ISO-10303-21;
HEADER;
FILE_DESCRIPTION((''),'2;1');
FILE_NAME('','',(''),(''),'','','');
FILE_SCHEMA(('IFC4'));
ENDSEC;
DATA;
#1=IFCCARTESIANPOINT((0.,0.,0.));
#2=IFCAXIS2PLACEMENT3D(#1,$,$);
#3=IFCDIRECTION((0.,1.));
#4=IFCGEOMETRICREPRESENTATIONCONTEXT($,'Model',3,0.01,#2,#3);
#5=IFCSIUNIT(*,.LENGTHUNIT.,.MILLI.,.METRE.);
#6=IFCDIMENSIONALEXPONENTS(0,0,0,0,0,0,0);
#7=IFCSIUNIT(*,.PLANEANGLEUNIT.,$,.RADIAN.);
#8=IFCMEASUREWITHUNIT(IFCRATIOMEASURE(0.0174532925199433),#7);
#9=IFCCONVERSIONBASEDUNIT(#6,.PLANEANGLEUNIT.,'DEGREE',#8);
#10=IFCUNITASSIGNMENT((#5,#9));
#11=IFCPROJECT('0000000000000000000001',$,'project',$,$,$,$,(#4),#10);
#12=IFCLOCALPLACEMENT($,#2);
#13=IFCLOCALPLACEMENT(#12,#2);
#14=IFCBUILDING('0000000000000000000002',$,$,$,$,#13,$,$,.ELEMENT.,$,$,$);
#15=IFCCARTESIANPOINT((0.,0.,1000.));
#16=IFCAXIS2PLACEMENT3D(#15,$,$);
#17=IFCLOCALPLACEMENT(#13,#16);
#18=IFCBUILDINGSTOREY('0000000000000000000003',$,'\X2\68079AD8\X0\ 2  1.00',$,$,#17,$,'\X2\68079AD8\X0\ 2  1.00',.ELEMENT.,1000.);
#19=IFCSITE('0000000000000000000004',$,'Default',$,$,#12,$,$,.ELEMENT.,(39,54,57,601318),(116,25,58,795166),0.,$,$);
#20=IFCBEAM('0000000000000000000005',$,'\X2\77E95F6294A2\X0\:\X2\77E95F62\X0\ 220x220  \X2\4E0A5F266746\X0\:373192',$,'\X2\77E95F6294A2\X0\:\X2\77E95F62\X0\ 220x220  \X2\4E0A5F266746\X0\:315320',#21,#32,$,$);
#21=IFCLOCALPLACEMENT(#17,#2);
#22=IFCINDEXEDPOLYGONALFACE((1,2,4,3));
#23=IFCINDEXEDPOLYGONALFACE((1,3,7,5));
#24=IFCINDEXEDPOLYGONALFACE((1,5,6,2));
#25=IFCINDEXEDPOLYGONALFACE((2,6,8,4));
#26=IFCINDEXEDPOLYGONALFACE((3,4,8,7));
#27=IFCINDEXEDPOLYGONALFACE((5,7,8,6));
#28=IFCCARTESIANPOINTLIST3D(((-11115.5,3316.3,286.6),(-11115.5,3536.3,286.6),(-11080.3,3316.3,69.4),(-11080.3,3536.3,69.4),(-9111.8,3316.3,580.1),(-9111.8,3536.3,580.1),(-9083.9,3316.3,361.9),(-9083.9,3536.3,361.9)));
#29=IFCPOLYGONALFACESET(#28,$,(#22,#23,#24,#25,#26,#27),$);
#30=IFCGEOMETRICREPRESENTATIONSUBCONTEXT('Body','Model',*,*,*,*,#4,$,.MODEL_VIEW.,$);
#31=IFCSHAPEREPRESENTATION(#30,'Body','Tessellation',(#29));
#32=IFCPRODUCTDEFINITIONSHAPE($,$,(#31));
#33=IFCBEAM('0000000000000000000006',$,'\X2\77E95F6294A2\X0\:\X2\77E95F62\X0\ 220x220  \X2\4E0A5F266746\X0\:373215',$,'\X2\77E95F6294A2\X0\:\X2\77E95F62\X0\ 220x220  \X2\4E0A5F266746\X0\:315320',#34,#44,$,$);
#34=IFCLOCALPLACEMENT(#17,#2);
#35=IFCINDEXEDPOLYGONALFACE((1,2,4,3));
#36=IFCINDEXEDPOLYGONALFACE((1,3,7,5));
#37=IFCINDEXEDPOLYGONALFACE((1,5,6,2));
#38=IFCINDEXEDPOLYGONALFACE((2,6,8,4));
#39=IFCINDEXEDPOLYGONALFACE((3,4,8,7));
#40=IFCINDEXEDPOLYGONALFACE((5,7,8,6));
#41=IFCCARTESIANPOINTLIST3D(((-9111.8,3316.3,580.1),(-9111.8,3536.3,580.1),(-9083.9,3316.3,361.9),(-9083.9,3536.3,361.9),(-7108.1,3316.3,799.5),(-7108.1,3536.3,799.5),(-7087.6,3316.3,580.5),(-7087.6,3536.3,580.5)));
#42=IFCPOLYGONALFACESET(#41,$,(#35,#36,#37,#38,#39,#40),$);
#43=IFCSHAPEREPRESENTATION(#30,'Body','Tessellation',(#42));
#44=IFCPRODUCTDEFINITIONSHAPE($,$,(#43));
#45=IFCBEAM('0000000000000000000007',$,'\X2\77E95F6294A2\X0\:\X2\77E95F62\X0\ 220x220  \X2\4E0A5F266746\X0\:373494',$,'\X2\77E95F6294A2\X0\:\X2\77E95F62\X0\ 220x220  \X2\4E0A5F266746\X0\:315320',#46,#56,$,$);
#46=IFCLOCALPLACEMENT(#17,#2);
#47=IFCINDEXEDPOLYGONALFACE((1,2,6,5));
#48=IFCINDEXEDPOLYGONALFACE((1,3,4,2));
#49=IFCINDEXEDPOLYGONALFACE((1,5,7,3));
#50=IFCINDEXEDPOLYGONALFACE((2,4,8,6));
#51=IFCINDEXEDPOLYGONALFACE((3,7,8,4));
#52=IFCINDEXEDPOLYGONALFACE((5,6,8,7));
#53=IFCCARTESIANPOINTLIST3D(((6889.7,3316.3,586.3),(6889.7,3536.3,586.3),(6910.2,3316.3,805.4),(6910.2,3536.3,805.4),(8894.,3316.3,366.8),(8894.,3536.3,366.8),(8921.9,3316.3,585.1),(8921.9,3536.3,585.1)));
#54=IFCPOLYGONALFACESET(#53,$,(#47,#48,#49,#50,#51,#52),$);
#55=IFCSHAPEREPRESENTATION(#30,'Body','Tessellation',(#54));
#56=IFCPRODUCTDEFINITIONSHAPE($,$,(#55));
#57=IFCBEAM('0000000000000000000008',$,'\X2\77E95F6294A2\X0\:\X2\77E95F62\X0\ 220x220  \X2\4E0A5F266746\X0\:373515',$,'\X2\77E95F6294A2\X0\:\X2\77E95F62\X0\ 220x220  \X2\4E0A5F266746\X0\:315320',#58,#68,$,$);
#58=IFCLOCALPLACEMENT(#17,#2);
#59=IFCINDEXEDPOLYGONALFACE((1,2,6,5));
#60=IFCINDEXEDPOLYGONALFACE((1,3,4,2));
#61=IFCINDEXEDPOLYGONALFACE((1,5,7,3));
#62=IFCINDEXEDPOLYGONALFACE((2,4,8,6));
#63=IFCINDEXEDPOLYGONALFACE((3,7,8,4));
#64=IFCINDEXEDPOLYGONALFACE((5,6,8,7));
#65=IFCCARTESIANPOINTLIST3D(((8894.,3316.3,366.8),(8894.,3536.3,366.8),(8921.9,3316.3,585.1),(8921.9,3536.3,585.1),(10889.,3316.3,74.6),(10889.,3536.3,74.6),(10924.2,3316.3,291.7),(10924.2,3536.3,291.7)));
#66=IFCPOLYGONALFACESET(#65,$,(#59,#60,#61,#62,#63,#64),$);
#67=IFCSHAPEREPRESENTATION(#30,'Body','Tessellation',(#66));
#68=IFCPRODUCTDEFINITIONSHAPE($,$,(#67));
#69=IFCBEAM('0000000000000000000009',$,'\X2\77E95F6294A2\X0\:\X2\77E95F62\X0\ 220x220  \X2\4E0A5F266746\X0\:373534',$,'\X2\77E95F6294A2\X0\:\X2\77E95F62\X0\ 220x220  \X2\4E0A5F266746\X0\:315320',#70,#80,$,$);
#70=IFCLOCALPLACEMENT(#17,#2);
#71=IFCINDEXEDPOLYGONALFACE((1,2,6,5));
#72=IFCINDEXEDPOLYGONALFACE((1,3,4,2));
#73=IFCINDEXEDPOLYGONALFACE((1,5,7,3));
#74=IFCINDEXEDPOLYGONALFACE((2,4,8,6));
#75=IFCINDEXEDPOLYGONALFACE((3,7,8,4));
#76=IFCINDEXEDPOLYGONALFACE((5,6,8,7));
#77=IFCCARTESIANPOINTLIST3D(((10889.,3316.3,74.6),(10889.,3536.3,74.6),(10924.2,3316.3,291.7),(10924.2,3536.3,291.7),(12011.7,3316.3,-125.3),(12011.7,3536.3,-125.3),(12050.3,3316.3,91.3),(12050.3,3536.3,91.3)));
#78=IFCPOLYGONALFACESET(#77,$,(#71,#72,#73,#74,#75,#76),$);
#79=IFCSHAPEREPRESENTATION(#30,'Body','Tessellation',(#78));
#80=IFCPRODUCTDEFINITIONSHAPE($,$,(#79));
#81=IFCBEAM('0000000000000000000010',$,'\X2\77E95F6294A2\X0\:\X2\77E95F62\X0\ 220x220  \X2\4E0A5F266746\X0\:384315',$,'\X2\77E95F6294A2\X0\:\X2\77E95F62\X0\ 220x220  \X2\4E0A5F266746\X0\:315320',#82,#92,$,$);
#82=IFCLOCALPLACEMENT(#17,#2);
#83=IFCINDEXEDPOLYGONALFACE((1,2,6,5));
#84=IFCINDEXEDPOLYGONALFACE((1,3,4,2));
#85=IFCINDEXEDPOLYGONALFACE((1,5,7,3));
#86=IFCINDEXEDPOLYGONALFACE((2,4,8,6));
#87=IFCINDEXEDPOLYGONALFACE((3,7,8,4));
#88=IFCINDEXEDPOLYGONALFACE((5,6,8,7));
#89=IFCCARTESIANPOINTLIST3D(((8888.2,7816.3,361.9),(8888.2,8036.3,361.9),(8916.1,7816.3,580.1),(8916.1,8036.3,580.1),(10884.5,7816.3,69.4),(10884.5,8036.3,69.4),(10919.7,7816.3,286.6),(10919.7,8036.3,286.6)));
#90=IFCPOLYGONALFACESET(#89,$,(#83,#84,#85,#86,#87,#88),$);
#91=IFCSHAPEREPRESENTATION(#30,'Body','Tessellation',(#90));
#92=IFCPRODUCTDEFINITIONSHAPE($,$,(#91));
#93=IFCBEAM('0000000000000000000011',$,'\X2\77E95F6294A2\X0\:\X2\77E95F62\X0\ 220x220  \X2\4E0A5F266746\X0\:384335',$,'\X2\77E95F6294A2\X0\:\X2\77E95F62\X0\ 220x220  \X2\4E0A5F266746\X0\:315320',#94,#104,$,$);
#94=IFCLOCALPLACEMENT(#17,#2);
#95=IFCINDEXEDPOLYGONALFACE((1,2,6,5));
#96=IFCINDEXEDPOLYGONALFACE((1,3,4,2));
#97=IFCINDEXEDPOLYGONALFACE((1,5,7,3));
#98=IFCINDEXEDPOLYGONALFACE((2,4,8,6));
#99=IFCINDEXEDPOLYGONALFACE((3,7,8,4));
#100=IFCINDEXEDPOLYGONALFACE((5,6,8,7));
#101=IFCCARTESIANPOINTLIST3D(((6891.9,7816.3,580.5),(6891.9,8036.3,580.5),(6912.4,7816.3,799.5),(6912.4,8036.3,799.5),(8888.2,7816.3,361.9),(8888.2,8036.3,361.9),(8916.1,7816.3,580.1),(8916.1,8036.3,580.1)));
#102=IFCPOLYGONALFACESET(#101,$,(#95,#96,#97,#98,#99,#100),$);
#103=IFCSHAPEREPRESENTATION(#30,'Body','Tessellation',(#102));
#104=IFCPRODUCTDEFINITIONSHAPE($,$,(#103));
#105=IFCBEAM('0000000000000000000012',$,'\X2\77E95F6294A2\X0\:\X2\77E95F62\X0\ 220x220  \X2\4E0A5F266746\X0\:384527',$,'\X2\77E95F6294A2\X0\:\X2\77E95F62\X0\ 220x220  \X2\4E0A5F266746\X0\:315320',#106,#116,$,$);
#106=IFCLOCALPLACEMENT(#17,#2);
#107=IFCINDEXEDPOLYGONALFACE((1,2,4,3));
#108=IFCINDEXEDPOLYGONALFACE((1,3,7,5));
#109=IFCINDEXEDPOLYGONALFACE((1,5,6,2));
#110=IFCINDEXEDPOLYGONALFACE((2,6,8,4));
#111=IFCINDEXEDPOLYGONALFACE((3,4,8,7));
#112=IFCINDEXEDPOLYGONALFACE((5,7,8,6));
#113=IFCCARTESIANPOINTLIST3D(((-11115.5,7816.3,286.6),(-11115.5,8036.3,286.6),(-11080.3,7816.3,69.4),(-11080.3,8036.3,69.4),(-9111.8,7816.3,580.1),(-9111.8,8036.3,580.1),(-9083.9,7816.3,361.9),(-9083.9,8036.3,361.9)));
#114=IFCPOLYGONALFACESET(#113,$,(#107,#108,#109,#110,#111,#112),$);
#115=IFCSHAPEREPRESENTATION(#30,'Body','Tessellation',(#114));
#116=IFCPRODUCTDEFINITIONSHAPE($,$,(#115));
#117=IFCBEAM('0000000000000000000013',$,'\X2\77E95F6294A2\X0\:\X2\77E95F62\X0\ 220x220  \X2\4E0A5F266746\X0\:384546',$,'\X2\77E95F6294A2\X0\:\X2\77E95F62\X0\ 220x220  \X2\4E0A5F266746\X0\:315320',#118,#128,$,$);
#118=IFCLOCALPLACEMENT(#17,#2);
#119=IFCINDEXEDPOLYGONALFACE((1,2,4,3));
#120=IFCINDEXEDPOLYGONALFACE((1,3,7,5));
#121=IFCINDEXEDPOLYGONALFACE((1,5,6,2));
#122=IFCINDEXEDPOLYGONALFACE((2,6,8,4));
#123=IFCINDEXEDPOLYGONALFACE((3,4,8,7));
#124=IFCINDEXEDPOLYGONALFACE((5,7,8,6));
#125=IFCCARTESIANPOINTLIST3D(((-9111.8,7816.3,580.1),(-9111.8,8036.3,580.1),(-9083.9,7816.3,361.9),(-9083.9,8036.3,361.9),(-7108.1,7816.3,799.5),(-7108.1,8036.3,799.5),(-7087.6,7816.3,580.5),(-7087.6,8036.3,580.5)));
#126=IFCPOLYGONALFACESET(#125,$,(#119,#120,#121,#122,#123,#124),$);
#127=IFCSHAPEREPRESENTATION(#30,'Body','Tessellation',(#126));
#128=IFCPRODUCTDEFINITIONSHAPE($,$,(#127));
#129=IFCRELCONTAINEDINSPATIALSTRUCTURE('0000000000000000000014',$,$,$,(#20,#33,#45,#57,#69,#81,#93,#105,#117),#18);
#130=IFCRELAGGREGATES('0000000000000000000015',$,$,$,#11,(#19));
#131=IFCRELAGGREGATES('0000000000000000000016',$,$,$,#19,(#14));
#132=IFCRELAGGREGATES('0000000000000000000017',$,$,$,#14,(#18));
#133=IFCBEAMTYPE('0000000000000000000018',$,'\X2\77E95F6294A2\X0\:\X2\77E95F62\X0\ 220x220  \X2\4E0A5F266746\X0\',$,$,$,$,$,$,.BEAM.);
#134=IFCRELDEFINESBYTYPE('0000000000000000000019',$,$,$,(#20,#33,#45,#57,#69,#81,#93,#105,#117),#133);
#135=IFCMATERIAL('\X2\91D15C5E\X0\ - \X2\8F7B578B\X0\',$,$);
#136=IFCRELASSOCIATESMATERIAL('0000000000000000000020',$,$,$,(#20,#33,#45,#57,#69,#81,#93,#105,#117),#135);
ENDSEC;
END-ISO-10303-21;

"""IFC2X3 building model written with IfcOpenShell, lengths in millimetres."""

from ifc_helpers import new_model, entity, si_unit, converted_unit, direction, frame, frame_2d, origin, origin_2d_with_axis, place, context, subcontext, project, spatial, rectangle, extrude, clip, halfspace, material, type_object, element, save


model = new_model("IFC2X3")

# Units and contexts
model_context = context("Model", 3, precision=0.01, world=origin(), true_north=direction((0.0, 1.0)))
body_context = subcontext(model_context, "Body", "Model", "MODEL_VIEW")
ifc_project = project(units=[si_unit("LENGTHUNIT", "METRE", prefix="MILLI"), converted_unit("PLANEANGLEUNIT", "DEGREE", entity("IfcRatioMeasure", 0.0174532925199433), si_unit("PLANEANGLEUNIT", "RADIAN"), dimensions=[0, 0, 0, 0, 0, 0, 0])], contexts=[model_context])

# Site, building, storey
site_placement = place(None, origin())
site = spatial("IfcSite", under=ifc_project, at=site_placement, Name="Default", CompositionType="ELEMENT", RefLatitude=(39, 54, 57, 601318), RefLongitude=(116, 25, 58, 795166), RefElevation=0.0)
building_placement = place(site_placement, origin())
building = spatial("IfcBuilding", under=site, at=building_placement, CompositionType="ELEMENT")
storey_placement = place(building_placement, frame((0.0, 0.0, 1000.0)))
storey = spatial("IfcBuildingStorey", under=building, at=storey_placement, Name="标高 2  1.00", LongName="标高 2  1.00", CompositionType="ELEMENT", Elevation=1000.0)

# Beams
ifc_material = material(Name="金属 - 轻型")
beam_type = type_object("IfcBeamType", Name="矩形钢:矩形 220x220  上弦杆", PredefinedType="BEAM")
beam_1_placement = place(storey_placement, frame((-11097.9, 3426.3, 178.0), z_axis=(-0.144953, 0.0, 0.989439), x_axis=(0.989439, 0.0, 0.144953)))
element("IfcBeam", 1, at=beam_1_placement, inside=storey, type_object=beam_type, material=ifc_material, Name="矩形钢:矩形 220x220  上弦杆:373192", ObjectType="矩形钢:矩形 220x220  上弦杆:315320", context=body_context, shape_type="Clipping", body=[
    clip(clip(extrude(rectangle(XDim=220.0, YDim=220.0, at=frame_2d((0.0, 0.0), x_axis=(1.0, 0.0))), frame((-1.7, 0.0, 0.0), z_axis=(1.0, 0.0, 0.0), x_axis=(0.0, 0.0, -1.0)), (0.0, 0.0, 1.0), 2025.0), halfspace(frame((2023.4, 0.0, 110.0), z_axis=(0.999834, 0.0, -0.018199), x_axis=(-0.018199, 0.0, -0.999834)), False)), halfspace(frame((-1.7, 0.0, 110.0), z_axis=(-0.999882, 0.0, -0.015344), x_axis=(0.015344, 0.0, -0.999882)), False)),
])
beam_2_placement = place(storey_placement, frame((-9097.9, 3426.3, 471.0), z_axis=(-0.108849, 0.0, 0.994058), x_axis=(0.994058, 0.0, 0.108849)))
element("IfcBeam", 2, at=beam_2_placement, inside=storey, type_object=beam_type, material=ifc_material, Name="矩形钢:矩形 220x220  上弦杆:373215", ObjectType="矩形钢:矩形 220x220  上弦杆:315320", context=body_context, shape_type="Clipping", body=[
    clip(clip(extrude(rectangle(XDim=220.0, YDim=220.0, at=origin_2d_with_axis()), frame((-2.0, 0.0, 0.0), z_axis=(1.0, 0.0, 0.0), x_axis=(0.0, 0.0, -1.0)), (0.0, 0.0, 1.0), 2015.7), halfspace(frame((2013.7, 0.0, 110.0), z_axis=(0.999878, 0.0, -0.015611), x_axis=(-0.015611, 0.0, -0.999878)), False)), halfspace(frame((-2.0, 0.0, 110.0), z_axis=(-0.999834, 0.0, -0.018199), x_axis=(0.018199, 0.0, -0.999834)), False)),
])
beam_3_placement = place(storey_placement, frame((6899.9, 3426.3, 695.8), z_axis=(0.108849, 0.0, 0.994058), x_axis=(0.994058, 0.0, -0.108849)))
element("IfcBeam", 3, at=beam_3_placement, inside=storey, type_object=beam_type, material=ifc_material, Name="矩形钢:矩形 220x220  上弦杆:373494", ObjectType="矩形钢:矩形 220x220  上弦杆:315320", context=body_context, shape_type="Clipping", body=[
    clip(clip(extrude(rectangle(XDim=220.0, YDim=220.0, at=frame_2d((0.0, 0.0), x_axis=(1.0, 0.0))), frame((-1.7, 0.0, 0.0), z_axis=(1.0, 0.0, 0.0), x_axis=(0.0, 0.0, -1.0)), (0.0, 0.0, 1.0), 2023.7), halfspace(frame((2022.0, 0.0, 110.0), z_axis=(0.999834, 0.0, -0.018199), x_axis=(0.018199, 0.0, 0.999834)), False)), halfspace(frame((-1.7, 0.0, 110.0), z_axis=(-0.999878, 0.0, -0.015611), x_axis=(-0.015611, 0.0, 0.999878)), False)),
])
beam_4_placement = place(storey_placement, frame((8907.9, 3426.3, 476.0), z_axis=(0.144953, 0.0, 0.989439), x_axis=(0.989439, 0.0, -0.144953)))
element("IfcBeam", 4, at=beam_4_placement, inside=storey, type_object=beam_type, material=ifc_material, Name="矩形钢:矩形 220x220  上弦杆:373515", ObjectType="矩形钢:矩形 220x220  上弦杆:315320", context=body_context, shape_type="Clipping", body=[
    clip(clip(extrude(rectangle(XDim=220.0, YDim=220.0, at=frame_2d((0.0, 0.0), x_axis=(1.0, 0.0))), frame((-2.0, 0.0, 0.0), z_axis=(1.0, 0.0, 0.0), x_axis=(0.0, 0.0, -1.0)), (0.0, 0.0, 1.0), 2023.7), halfspace(frame((2021.7, 0.0, 110.0), z_axis=(0.999882, 0.0, -0.015344), x_axis=(0.015344, 0.0, 0.999882)), False)), halfspace(frame((-2.0, 0.0, 110.0), z_axis=(-0.999834, 0.0, -0.018199), x_axis=(-0.018199, 0.0, 0.999834)), False)),
])
beam_5_placement = place(storey_placement, frame((10906.6, 3426.3, 183.2), z_axis=(0.175245, 0.0, 0.984525), x_axis=(0.984525, 0.0, -0.175245)))
element("IfcBeam", 5, at=beam_5_placement, inside=storey, type_object=beam_type, material=ifc_material, Name="矩形钢:矩形 220x220  上弦杆:373534", ObjectType="矩形钢:矩形 220x220  上弦杆:315320", context=body_context, shape_type="Clipping", body=[
    clip(extrude(rectangle(XDim=220.0, YDim=220.0, at=frame_2d((0.0, 0.0), x_axis=(1.0, 0.0))), frame((-1.7, 0.0, 0.0), z_axis=(1.0, 0.0, 0.0), x_axis=(0.0, 0.0, -1.0)), (0.0, 0.0, 1.0), 1143.8), halfspace(frame((-1.7, 0.0, 110.0), z_axis=(-0.999882, 0.0, -0.015344), x_axis=(-0.015344, 0.0, 0.999882)), False)),
])
beam_6_placement = place(storey_placement, frame((10902.1, 7926.3, 178.0), z_axis=(0.144953, 0.0, 0.989439), x_axis=(-0.989439, 0.0, 0.144953)))
element("IfcBeam", 6, at=beam_6_placement, inside=storey, type_object=beam_type, material=ifc_material, Name="矩形钢:矩形 220x220  上弦杆:384315", ObjectType="矩形钢:矩形 220x220  上弦杆:315320", context=body_context, shape_type="Clipping", body=[
    clip(clip(extrude(rectangle(XDim=220.0, YDim=220.0, at=frame_2d((0.0, 0.0), x_axis=(1.0, 0.0))), frame((-1.7, 0.0, 0.0), z_axis=(1.0, 0.0, 0.0), x_axis=(0.0, 0.0, -1.0)), (0.0, 0.0, 1.0), 2025.0), halfspace(frame((2023.4, 0.0, 110.0), z_axis=(0.999834, 0.0, -0.018199), x_axis=(0.018199, 0.0, 0.999834)), False)), halfspace(frame((-1.7, 0.0, 110.0), z_axis=(-0.999882, 0.0, -0.015344), x_axis=(-0.015344, 0.0, 0.999882)), False)),
])
beam_7_placement = place(storey_placement, frame((8902.1, 7926.3, 471.0), z_axis=(0.108849, 0.0, 0.994058), x_axis=(-0.994058, 0.0, 0.108849)))
element("IfcBeam", 7, at=beam_7_placement, inside=storey, type_object=beam_type, material=ifc_material, Name="矩形钢:矩形 220x220  上弦杆:384335", ObjectType="矩形钢:矩形 220x220  上弦杆:315320", context=body_context, shape_type="Clipping", body=[
    clip(clip(extrude(rectangle(XDim=220.0, YDim=220.0, at=frame_2d((0.0, 0.0), x_axis=(1.0, 0.0))), frame((-2.0, 0.0, 0.0), z_axis=(1.0, 0.0, 0.0), x_axis=(0.0, 0.0, -1.0)), (0.0, 0.0, 1.0), 2015.7), halfspace(frame((2013.7, 0.0, 110.0), z_axis=(0.999878, 0.0, -0.015611), x_axis=(0.015611, 0.0, 0.999878)), False)), halfspace(frame((-2.0, 0.0, 110.0), z_axis=(-0.999834, 0.0, -0.018199), x_axis=(-0.018199, 0.0, 0.999834)), False)),
])
beam_8_placement = place(storey_placement, frame((-11097.9, 7926.3, 178.0), z_axis=(-0.144953, 0.0, 0.989439), x_axis=(0.989439, 0.0, 0.144953)))
element("IfcBeam", 8, at=beam_8_placement, inside=storey, type_object=beam_type, material=ifc_material, Name="矩形钢:矩形 220x220  上弦杆:384527", ObjectType="矩形钢:矩形 220x220  上弦杆:315320", context=body_context, shape_type="Clipping", body=[
    clip(clip(extrude(rectangle(XDim=220.0, YDim=220.0, at=frame_2d((0.0, 0.0), x_axis=(1.0, 0.0))), frame((-1.7, 0.0, 0.0), z_axis=(1.0, 0.0, 0.0), x_axis=(0.0, 0.0, -1.0)), (0.0, 0.0, 1.0), 2025.0), halfspace(frame((2023.4, 0.0, 110.0), z_axis=(0.999834, 0.0, -0.018199), x_axis=(-0.018199, 0.0, -0.999834)), False)), halfspace(frame((-1.7, 0.0, 110.0), z_axis=(-0.999882, 0.0, -0.015344), x_axis=(0.015344, 0.0, -0.999882)), False)),
])
beam_9_placement = place(storey_placement, frame((-9097.9, 7926.3, 471.0), z_axis=(-0.108849, 0.0, 0.994058), x_axis=(0.994058, 0.0, 0.108849)))
element("IfcBeam", 9, at=beam_9_placement, inside=storey, type_object=beam_type, material=ifc_material, Name="矩形钢:矩形 220x220  上弦杆:384546", ObjectType="矩形钢:矩形 220x220  上弦杆:315320", context=body_context, shape_type="Clipping", body=[
    clip(clip(extrude(rectangle(XDim=220.0, YDim=220.0, at=frame_2d((0.0, 0.0), x_axis=(1.0, 0.0))), frame((-2.0, 0.0, 0.0), z_axis=(1.0, 0.0, 0.0), x_axis=(0.0, 0.0, -1.0)), (0.0, 0.0, 1.0), 2015.7), halfspace(frame((-2.0, 0.0, 110.0), z_axis=(-0.999834, 0.0, -0.018199), x_axis=(0.018199, 0.0, -0.999834)), False)), halfspace(frame((2013.7, 0.0, 110.0), z_axis=(0.999878, 0.0, -0.015611), x_axis=(-0.015611, 0.0, -0.999878)), False)),
])

save(model, "model.ifc")
